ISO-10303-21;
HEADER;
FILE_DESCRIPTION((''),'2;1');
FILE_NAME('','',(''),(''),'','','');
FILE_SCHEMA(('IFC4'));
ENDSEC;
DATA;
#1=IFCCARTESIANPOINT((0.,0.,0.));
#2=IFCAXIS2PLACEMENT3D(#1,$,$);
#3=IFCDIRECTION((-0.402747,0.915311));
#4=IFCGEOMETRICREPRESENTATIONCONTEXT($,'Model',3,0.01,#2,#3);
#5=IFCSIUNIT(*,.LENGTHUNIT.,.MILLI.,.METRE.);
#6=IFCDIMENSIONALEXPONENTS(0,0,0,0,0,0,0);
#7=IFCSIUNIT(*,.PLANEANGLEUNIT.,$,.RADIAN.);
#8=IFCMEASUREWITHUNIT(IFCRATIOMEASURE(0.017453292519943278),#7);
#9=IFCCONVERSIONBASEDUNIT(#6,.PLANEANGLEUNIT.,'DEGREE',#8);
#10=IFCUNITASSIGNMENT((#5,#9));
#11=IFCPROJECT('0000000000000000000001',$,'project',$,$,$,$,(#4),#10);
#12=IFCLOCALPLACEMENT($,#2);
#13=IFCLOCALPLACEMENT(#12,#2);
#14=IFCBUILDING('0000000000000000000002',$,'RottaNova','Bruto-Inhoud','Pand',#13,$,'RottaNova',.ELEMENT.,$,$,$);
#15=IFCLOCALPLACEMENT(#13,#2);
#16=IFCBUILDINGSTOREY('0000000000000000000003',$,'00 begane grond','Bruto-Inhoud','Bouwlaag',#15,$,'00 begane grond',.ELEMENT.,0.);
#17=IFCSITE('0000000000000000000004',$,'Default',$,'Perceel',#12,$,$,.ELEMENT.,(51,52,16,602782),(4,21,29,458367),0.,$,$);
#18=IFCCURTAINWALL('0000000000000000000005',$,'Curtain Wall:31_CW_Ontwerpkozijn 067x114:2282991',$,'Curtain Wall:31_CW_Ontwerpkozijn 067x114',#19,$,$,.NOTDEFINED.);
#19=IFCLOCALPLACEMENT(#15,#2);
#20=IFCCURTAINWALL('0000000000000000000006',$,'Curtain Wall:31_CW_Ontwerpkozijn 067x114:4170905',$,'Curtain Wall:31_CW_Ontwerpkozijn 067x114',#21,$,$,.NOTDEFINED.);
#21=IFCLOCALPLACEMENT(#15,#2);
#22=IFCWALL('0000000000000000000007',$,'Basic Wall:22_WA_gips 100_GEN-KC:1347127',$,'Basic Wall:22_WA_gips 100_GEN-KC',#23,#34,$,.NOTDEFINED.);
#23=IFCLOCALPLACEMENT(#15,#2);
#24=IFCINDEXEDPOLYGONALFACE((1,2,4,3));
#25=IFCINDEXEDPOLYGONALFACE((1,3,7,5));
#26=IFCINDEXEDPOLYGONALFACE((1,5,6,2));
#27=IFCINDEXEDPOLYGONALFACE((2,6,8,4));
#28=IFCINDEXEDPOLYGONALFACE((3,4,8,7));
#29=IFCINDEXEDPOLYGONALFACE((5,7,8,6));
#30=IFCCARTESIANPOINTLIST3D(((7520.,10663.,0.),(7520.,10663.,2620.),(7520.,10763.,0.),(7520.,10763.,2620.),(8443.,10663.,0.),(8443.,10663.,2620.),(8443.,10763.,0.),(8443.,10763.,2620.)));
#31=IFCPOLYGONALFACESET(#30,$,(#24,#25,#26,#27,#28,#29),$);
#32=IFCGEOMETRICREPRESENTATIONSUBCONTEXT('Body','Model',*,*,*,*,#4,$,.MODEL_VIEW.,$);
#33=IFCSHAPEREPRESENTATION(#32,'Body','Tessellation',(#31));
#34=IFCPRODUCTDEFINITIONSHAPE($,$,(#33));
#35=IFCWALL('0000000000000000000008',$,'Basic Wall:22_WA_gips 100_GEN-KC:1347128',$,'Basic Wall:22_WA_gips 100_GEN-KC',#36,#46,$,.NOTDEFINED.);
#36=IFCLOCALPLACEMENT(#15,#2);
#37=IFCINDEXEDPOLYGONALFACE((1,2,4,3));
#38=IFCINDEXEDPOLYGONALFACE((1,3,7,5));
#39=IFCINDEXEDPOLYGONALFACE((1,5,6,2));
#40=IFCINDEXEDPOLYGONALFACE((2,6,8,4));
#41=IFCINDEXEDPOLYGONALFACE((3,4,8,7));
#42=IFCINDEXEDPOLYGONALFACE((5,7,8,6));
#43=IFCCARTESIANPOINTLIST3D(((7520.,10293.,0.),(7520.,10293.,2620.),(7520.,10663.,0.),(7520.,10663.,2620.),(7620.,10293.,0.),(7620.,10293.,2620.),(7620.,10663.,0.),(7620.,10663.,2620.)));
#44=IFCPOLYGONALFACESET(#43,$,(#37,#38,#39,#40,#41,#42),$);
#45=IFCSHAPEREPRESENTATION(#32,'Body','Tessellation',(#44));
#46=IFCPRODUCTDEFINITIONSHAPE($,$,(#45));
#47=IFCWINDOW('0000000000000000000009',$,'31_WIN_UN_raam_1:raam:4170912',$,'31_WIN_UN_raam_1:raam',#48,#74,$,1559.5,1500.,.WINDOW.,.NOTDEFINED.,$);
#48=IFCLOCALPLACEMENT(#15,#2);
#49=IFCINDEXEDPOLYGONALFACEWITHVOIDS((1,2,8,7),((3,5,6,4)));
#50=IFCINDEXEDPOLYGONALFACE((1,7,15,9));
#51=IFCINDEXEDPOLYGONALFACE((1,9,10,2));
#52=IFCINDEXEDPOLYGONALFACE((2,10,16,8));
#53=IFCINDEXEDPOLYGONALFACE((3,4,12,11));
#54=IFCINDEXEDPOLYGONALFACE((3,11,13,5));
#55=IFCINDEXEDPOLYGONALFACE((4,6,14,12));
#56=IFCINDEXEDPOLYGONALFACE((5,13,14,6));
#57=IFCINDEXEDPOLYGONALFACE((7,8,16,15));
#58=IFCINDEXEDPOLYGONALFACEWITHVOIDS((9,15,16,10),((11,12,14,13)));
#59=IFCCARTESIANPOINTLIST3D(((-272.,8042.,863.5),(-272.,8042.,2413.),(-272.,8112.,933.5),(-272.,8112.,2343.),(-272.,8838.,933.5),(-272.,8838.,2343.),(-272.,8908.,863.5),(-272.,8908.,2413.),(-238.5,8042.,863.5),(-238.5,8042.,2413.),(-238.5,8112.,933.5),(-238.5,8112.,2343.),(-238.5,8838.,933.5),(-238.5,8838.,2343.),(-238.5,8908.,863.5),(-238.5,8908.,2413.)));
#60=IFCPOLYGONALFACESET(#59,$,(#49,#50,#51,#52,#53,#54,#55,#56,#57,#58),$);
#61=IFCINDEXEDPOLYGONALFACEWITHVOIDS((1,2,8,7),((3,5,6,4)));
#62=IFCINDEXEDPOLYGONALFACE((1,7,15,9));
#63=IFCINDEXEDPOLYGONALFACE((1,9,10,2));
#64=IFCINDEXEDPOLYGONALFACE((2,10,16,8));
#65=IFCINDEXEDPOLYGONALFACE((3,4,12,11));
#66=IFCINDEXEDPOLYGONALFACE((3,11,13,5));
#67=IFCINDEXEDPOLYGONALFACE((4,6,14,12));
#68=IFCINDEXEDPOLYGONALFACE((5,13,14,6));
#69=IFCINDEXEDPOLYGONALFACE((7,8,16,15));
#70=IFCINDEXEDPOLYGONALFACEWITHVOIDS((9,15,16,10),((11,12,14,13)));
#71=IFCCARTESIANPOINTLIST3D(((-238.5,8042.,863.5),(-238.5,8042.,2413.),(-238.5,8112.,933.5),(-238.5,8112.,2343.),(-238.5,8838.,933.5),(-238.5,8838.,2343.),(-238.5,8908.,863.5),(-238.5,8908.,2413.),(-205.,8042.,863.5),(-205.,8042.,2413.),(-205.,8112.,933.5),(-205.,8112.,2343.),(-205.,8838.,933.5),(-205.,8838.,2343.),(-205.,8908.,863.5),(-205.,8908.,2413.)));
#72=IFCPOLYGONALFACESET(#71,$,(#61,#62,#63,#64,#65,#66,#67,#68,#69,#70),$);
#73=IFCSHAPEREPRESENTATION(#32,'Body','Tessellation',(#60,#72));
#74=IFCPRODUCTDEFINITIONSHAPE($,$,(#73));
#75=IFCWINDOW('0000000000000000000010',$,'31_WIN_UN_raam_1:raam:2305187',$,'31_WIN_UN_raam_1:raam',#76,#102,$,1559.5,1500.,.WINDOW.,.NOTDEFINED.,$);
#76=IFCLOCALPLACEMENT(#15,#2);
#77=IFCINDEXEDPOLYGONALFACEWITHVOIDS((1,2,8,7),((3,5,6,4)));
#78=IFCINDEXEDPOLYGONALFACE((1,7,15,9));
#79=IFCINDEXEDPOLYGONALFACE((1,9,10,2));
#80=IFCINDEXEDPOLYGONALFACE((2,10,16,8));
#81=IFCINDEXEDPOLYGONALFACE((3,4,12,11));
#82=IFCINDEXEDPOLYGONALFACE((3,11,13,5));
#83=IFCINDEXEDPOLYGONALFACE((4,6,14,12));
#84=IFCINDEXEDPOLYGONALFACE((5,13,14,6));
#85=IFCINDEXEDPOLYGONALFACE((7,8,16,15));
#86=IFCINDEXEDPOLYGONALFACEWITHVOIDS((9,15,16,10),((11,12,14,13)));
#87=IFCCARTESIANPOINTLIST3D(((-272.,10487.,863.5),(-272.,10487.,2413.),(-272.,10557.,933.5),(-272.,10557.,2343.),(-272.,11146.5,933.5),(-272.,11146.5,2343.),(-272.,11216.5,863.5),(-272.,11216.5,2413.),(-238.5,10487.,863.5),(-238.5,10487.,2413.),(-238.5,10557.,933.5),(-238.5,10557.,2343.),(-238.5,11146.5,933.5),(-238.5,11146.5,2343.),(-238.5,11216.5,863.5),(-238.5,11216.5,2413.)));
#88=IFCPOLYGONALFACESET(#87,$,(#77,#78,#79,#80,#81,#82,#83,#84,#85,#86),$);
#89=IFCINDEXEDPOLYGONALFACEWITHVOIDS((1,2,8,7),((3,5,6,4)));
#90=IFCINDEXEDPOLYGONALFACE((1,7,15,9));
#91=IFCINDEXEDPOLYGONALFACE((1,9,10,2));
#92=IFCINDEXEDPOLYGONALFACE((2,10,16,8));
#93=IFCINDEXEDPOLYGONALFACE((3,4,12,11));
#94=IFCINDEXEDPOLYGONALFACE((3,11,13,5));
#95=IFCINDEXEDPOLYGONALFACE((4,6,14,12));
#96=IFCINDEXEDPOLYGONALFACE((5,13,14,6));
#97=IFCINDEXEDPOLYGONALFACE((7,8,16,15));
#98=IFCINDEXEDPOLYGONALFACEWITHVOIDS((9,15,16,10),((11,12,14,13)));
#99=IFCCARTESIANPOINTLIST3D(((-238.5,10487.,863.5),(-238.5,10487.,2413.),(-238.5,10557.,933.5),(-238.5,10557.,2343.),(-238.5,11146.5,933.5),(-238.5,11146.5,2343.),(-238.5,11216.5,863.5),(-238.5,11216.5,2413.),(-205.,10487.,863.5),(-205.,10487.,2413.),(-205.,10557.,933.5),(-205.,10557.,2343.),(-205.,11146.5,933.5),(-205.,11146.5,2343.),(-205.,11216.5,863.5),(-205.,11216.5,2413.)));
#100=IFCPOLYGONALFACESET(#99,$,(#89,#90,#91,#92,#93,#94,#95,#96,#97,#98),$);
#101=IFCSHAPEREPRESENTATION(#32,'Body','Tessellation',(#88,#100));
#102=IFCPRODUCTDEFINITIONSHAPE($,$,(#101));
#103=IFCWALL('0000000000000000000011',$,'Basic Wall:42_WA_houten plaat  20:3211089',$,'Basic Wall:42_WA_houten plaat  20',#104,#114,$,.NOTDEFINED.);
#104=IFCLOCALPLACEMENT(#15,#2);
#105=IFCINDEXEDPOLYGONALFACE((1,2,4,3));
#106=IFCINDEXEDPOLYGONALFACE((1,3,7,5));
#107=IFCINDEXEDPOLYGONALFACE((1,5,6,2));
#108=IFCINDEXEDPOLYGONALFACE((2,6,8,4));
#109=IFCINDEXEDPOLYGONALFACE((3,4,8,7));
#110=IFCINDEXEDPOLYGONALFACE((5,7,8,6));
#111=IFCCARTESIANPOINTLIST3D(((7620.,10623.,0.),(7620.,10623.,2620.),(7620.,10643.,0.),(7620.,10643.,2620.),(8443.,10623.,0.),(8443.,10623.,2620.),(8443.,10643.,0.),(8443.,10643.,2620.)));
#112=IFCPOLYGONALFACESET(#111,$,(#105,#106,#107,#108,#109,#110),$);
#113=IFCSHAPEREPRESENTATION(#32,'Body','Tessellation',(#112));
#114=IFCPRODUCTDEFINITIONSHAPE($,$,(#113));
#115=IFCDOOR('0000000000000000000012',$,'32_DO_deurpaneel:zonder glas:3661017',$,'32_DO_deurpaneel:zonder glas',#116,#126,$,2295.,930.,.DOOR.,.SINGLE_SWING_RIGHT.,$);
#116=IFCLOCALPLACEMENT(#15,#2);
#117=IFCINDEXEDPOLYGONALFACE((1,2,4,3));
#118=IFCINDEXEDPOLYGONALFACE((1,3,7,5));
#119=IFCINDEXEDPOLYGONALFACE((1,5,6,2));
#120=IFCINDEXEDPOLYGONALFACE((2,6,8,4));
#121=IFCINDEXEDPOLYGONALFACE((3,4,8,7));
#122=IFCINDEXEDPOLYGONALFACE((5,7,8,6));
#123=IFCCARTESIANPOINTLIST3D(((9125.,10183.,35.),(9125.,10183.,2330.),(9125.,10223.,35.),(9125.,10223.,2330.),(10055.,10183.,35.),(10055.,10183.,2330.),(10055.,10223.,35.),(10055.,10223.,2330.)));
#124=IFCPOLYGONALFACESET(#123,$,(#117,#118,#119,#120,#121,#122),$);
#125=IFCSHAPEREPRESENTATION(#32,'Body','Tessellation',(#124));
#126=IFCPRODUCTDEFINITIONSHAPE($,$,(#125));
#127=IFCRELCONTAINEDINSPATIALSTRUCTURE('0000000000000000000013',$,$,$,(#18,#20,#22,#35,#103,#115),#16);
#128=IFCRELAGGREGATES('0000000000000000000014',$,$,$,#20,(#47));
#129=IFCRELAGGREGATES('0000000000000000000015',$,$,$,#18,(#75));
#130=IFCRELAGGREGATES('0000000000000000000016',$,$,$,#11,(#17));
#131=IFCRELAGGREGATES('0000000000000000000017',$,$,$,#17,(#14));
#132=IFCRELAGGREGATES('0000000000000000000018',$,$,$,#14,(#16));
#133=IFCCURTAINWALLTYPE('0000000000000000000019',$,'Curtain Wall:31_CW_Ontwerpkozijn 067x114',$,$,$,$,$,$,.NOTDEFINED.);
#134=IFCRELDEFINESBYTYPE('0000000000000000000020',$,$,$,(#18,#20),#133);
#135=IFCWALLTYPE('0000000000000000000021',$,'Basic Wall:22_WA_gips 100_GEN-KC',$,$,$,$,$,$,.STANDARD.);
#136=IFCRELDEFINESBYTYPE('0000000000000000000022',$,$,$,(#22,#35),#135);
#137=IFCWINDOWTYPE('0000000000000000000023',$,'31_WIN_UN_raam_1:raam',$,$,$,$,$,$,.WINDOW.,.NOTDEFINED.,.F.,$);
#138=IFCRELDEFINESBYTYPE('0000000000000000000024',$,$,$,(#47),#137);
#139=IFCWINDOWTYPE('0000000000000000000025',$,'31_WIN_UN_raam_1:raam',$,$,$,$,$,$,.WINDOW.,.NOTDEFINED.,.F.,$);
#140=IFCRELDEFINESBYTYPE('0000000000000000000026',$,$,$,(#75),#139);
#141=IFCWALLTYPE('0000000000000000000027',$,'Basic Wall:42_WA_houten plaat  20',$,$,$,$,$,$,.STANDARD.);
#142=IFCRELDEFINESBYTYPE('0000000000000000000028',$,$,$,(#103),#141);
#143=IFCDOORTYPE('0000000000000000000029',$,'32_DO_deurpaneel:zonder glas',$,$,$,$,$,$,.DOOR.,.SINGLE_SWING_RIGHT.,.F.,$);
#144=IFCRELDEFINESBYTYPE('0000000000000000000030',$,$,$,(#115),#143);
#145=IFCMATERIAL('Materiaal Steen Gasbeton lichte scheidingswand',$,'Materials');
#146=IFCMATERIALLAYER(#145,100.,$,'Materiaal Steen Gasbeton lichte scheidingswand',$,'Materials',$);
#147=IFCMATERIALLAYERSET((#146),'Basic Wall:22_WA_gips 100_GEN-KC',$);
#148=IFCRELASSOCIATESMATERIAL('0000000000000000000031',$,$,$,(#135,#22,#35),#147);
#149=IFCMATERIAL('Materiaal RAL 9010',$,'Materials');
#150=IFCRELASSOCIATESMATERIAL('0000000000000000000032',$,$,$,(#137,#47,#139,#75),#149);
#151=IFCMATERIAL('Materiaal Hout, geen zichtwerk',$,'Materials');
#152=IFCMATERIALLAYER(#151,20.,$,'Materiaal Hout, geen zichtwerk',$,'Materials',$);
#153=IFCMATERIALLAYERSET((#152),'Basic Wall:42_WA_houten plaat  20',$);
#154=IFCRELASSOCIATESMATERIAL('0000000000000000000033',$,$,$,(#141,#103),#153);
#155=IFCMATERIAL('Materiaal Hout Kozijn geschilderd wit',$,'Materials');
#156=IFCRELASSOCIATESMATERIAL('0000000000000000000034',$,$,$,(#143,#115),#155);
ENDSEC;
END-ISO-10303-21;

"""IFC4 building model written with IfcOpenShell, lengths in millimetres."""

from ifc_helpers import new_model, entity, si_unit, converted_unit, direction, frame, frame_2d, origin, place, context, subcontext, project, spatial, polyline, rectangle, outline, extrude, source, transform, mapped, material, layer, layer_set, type_object, type_shapes, element, aggregate, save


model = new_model("IFC4")

# Units and contexts
model_context = context("Model", 3, precision=0.01, world=origin(), true_north=direction((-0.402747, 0.915311)))
body_context = subcontext(model_context, "Body", "Model", "MODEL_VIEW")
ifc_project = project(units=[si_unit("LENGTHUNIT", "METRE", prefix="MILLI"), converted_unit("PLANEANGLEUNIT", "DEGREE", entity("IfcRatioMeasure", 0.017453292519943278), si_unit("PLANEANGLEUNIT", "RADIAN"), dimensions=[0, 0, 0, 0, 0, 0, 0])], contexts=[model_context])

# Site, building, storey
site_placement = place(None, origin())
site = spatial("IfcSite", under=ifc_project, at=site_placement, Name="Default", ObjectType="Perceel", CompositionType="ELEMENT", RefLatitude=(51, 52, 16, 602782), RefLongitude=(4, 21, 29, 458367), RefElevation=0.0)
building_placement = place(site_placement, origin())
building = spatial("IfcBuilding", under=site, at=building_placement, Name="RottaNova", Description="Bruto-Inhoud", ObjectType="Pand", LongName="RottaNova", CompositionType="ELEMENT")
storey_placement = place(building_placement, origin())
storey = spatial("IfcBuildingStorey", under=building, at=storey_placement, Name="00 begane grond", Description="Bruto-Inhoud", ObjectType="Bouwlaag", LongName="00 begane grond", CompositionType="ELEMENT", Elevation=0.0)

# Curtain walls
curtain_wall_type = type_object("IfcCurtainWallType", Name="Curtain Wall:31_CW_Ontwerpkozijn 067x114", PredefinedType="NOTDEFINED")
curtain_wall_1_placement = place(storey_placement, origin())
curtain_wall_1 = element("IfcCurtainWall", 1, at=curtain_wall_1_placement, inside=storey, type_object=curtain_wall_type, Name="Curtain Wall:31_CW_Ontwerpkozijn 067x114:2282991", ObjectType="Curtain Wall:31_CW_Ontwerpkozijn 067x114", PredefinedType="NOTDEFINED")
curtain_wall_2_placement = place(storey_placement, origin())
curtain_wall_2 = element("IfcCurtainWall", 2, at=curtain_wall_2_placement, inside=storey, type_object=curtain_wall_type, Name="Curtain Wall:31_CW_Ontwerpkozijn 067x114:4170905", ObjectType="Curtain Wall:31_CW_Ontwerpkozijn 067x114", PredefinedType="NOTDEFINED")

# Shared definitions
ifc_material_1 = material(Name="Materiaal Steen Gasbeton lichte scheidingswand", Category="Materials")
ifc_layer_1 = layer(ifc_material_1, 100.0, Name="Materiaal Steen Gasbeton lichte scheidingswand", Category="Materials")
ifc_layer_set_1 = layer_set([ifc_layer_1], Name="Basic Wall:22_WA_gips 100_GEN-KC")
wall_type_1 = type_object("IfcWallType", Name="Basic Wall:22_WA_gips 100_GEN-KC", PredefinedType="STANDARD", material=ifc_layer_set_1)

# Walls
wall_1_placement = place(storey_placement, frame((7520.0, 10713.0, 0.0)))
element("IfcWall", 3, at=wall_1_placement, inside=storey, type_object=wall_type_1, material=ifc_layer_set_1, Name="Basic Wall:22_WA_gips 100_GEN-KC:1347127", ObjectType="Basic Wall:22_WA_gips 100_GEN-KC", PredefinedType="NOTDEFINED", context=body_context, shape_type="SweptSolid", body=[
    extrude(rectangle(XDim=923.0, YDim=100.0, at=frame_2d((461.5, 0.0), x_axis=(-1.0, 0.0))), origin(), (0.0, 0.0, 1.0), 2620.0),
])
wall_2_placement = place(storey_placement, frame((7570.0, 10663.0, 0.0), z_axis=(0.0, 0.0, 1.0), x_axis=(0.0, -1.0, 0.0)))
element("IfcWall", 4, at=wall_2_placement, inside=storey, type_object=wall_type_1, material=ifc_layer_set_1, Name="Basic Wall:22_WA_gips 100_GEN-KC:1347128", ObjectType="Basic Wall:22_WA_gips 100_GEN-KC", PredefinedType="NOTDEFINED", context=body_context, shape_type="SweptSolid", body=[
    extrude(rectangle(XDim=370.0, YDim=100.0, at=frame_2d((185.0, 0.0), x_axis=(-1.0, 0.0))), origin(), (0.0, 0.0, 1.0), 2620.0),
])

# Windows
ifc_material_2 = material(Name="Materiaal RAL 9010", Category="Materials")
window_type_1 = type_object("IfcWindowType", Name="31_WIN_UN_raam_1:raam", ParameterTakesPrecedence=False, PartitioningType="NOTDEFINED", PredefinedType="WINDOW", material=ifc_material_2)
shared_shape_1 = source(origin(), body_context, "Body", "SweptSolid", [
    extrude(outline(polyline([(-433.0, -774.7), (433.0, -774.7), (433.0, 774.7), (-433.0, 774.7), (-433.0, -774.7)]), holes=[polyline([(-363.0, 704.7), (363.0, 704.7), (363.0, -704.8), (-363.0, -704.8), (-363.0, 704.7)])]), frame((0.0, 92.0, 774.8), z_axis=(0.0, -1.0, 0.0), x_axis=(-1.0, 0.0, 0.0)), (0.0, 0.0, 1.0), 33.5),
    extrude(outline(polyline([(-433.0, -774.7), (433.0, -774.7), (433.0, 774.7), (-433.0, 774.7), (-433.0, -774.7)]), holes=[polyline([(-363.0, 704.7), (363.0, 704.7), (363.0, -704.8), (-363.0, -704.8), (-363.0, 704.7)])]), frame((0.0, 58.5, 774.8), z_axis=(0.0, -1.0, 0.0), x_axis=(-1.0, 0.0, 0.0)), (0.0, 0.0, 1.0), 33.5),
])
type_shapes(window_type_1, [shared_shape_1])
window_1_placement = place(curtain_wall_2_placement, frame((-180.0, 8475.0, 863.5), z_axis=(0.0, 0.0, 1.0), x_axis=(0.0, 1.0, 0.0)))
window_1 = element("IfcWindow", 5, at=window_1_placement, type_object=window_type_1, material=ifc_material_2, Name="31_WIN_UN_raam_1:raam:4170912", ObjectType="31_WIN_UN_raam_1:raam", OverallHeight=1559.5, OverallWidth=1500.0, PartitioningType="NOTDEFINED", PredefinedType="WINDOW", context=body_context, shape_type="MappedRepresentation", body=[
    mapped(shared_shape_1, transform((0.0, 0.0, 0.0), scale=1.0)),
])
aggregate(curtain_wall_2, [window_1])
window_type_2 = type_object("IfcWindowType", Name="31_WIN_UN_raam_1:raam", ParameterTakesPrecedence=False, PartitioningType="NOTDEFINED", PredefinedType="WINDOW", material=ifc_material_2)
shared_shape_2 = source(origin(), body_context, "Body", "SweptSolid", [
    extrude(outline(polyline([(-364.7, -774.7), (364.7, -774.7), (364.7, 774.7), (-364.7, 774.7), (-364.7, -774.7)]), holes=[polyline([(-294.7, 704.7), (294.7, 704.7), (294.7, -704.8), (-294.7, -704.8), (-294.7, 704.7)])]), frame((0.0, 58.5, 774.8), z_axis=(0.0, 1.0, 0.0), x_axis=(1.0, 0.0, 0.0)), (0.0, 0.0, 1.0), 33.5),
    extrude(outline(polyline([(-364.7, -774.7), (364.7, -774.7), (364.7, 774.7), (-364.7, 774.7), (-364.7, -774.7)]), holes=[polyline([(-294.7, 704.7), (294.7, 704.7), (294.7, -704.8), (-294.7, -704.8), (-294.7, 704.7)])]), frame((0.0, 25.0, 774.8), z_axis=(0.0, 1.0, 0.0), x_axis=(1.0, 0.0, 0.0)), (0.0, 0.0, 1.0), 33.5),
])
type_shapes(window_type_2, [shared_shape_2])
window_2_placement = place(curtain_wall_1_placement, frame((-180.0, 10851.7, 863.5), z_axis=(0.0, 0.0, 1.0), x_axis=(0.0, 1.0, 0.0)))
window_2 = element("IfcWindow", 6, at=window_2_placement, type_object=window_type_2, material=ifc_material_2, Name="31_WIN_UN_raam_1:raam:2305187", ObjectType="31_WIN_UN_raam_1:raam", OverallHeight=1559.5, OverallWidth=1500.0, PartitioningType="NOTDEFINED", PredefinedType="WINDOW", context=body_context, shape_type="MappedRepresentation", body=[
    mapped(shared_shape_2, transform((0.0, 0.0, 0.0), scale=1.0)),
])
aggregate(curtain_wall_1, [window_2])

# Wall
ifc_material_3 = material(Name="Materiaal Hout, geen zichtwerk", Category="Materials")
ifc_layer_2 = layer(ifc_material_3, 20.0, Name="Materiaal Hout, geen zichtwerk", Category="Materials")
ifc_layer_set_2 = layer_set([ifc_layer_2], Name="Basic Wall:42_WA_houten plaat  20")
wall_type_2 = type_object("IfcWallType", Name="Basic Wall:42_WA_houten plaat  20", PredefinedType="STANDARD", material=ifc_layer_set_2)
wall_3_placement = place(storey_placement, frame((7620.0, 10633.0, 0.0)))
element("IfcWall", 7, at=wall_3_placement, inside=storey, type_object=wall_type_2, material=ifc_layer_set_2, Name="Basic Wall:42_WA_houten plaat  20:3211089", ObjectType="Basic Wall:42_WA_houten plaat  20", PredefinedType="NOTDEFINED", context=body_context, shape_type="SweptSolid", body=[
    extrude(rectangle(XDim=823.0, YDim=20.0, at=frame_2d((411.5, 0.0), x_axis=(-1.0, 0.0))), origin(), (0.0, 0.0, 1.0), 2620.0),
])

# Door
ifc_material_4 = material(Name="Materiaal Hout Kozijn geschilderd wit", Category="Materials")
door_type = type_object("IfcDoorType", Name="32_DO_deurpaneel:zonder glas", OperationType="SINGLE_SWING_RIGHT", ParameterTakesPrecedence=False, PredefinedType="DOOR", material=ifc_material_4)
shared_shape_3 = source(origin(), body_context, "Body", "SweptSolid", [
    extrude(rectangle(XDim=2295.0, YDim=40.0, at=frame_2d((0.0, 0.0), x_axis=(0.0, 1.0))), frame((-465.0, -20.0, 1182.5), z_axis=(1.0, 0.0, 0.0), x_axis=(0.0, 1.0, 0.0)), (0.0, 0.0, 1.0), 930.0),
])
type_shapes(door_type, [shared_shape_3])
door_placement = place(storey_placement, frame((9590.0, 10223.0, 0.0)))
element("IfcDoor", 8, at=door_placement, inside=storey, type_object=door_type, material=ifc_material_4, Name="32_DO_deurpaneel:zonder glas:3661017", ObjectType="32_DO_deurpaneel:zonder glas", OperationType="SINGLE_SWING_RIGHT", OverallHeight=2295.0, OverallWidth=930.0, PredefinedType="DOOR", context=body_context, shape_type="MappedRepresentation", body=[
    mapped(shared_shape_3, transform((0.0, 0.0, 0.0), scale=1.0)),
])

save(model, "model.ifc")
